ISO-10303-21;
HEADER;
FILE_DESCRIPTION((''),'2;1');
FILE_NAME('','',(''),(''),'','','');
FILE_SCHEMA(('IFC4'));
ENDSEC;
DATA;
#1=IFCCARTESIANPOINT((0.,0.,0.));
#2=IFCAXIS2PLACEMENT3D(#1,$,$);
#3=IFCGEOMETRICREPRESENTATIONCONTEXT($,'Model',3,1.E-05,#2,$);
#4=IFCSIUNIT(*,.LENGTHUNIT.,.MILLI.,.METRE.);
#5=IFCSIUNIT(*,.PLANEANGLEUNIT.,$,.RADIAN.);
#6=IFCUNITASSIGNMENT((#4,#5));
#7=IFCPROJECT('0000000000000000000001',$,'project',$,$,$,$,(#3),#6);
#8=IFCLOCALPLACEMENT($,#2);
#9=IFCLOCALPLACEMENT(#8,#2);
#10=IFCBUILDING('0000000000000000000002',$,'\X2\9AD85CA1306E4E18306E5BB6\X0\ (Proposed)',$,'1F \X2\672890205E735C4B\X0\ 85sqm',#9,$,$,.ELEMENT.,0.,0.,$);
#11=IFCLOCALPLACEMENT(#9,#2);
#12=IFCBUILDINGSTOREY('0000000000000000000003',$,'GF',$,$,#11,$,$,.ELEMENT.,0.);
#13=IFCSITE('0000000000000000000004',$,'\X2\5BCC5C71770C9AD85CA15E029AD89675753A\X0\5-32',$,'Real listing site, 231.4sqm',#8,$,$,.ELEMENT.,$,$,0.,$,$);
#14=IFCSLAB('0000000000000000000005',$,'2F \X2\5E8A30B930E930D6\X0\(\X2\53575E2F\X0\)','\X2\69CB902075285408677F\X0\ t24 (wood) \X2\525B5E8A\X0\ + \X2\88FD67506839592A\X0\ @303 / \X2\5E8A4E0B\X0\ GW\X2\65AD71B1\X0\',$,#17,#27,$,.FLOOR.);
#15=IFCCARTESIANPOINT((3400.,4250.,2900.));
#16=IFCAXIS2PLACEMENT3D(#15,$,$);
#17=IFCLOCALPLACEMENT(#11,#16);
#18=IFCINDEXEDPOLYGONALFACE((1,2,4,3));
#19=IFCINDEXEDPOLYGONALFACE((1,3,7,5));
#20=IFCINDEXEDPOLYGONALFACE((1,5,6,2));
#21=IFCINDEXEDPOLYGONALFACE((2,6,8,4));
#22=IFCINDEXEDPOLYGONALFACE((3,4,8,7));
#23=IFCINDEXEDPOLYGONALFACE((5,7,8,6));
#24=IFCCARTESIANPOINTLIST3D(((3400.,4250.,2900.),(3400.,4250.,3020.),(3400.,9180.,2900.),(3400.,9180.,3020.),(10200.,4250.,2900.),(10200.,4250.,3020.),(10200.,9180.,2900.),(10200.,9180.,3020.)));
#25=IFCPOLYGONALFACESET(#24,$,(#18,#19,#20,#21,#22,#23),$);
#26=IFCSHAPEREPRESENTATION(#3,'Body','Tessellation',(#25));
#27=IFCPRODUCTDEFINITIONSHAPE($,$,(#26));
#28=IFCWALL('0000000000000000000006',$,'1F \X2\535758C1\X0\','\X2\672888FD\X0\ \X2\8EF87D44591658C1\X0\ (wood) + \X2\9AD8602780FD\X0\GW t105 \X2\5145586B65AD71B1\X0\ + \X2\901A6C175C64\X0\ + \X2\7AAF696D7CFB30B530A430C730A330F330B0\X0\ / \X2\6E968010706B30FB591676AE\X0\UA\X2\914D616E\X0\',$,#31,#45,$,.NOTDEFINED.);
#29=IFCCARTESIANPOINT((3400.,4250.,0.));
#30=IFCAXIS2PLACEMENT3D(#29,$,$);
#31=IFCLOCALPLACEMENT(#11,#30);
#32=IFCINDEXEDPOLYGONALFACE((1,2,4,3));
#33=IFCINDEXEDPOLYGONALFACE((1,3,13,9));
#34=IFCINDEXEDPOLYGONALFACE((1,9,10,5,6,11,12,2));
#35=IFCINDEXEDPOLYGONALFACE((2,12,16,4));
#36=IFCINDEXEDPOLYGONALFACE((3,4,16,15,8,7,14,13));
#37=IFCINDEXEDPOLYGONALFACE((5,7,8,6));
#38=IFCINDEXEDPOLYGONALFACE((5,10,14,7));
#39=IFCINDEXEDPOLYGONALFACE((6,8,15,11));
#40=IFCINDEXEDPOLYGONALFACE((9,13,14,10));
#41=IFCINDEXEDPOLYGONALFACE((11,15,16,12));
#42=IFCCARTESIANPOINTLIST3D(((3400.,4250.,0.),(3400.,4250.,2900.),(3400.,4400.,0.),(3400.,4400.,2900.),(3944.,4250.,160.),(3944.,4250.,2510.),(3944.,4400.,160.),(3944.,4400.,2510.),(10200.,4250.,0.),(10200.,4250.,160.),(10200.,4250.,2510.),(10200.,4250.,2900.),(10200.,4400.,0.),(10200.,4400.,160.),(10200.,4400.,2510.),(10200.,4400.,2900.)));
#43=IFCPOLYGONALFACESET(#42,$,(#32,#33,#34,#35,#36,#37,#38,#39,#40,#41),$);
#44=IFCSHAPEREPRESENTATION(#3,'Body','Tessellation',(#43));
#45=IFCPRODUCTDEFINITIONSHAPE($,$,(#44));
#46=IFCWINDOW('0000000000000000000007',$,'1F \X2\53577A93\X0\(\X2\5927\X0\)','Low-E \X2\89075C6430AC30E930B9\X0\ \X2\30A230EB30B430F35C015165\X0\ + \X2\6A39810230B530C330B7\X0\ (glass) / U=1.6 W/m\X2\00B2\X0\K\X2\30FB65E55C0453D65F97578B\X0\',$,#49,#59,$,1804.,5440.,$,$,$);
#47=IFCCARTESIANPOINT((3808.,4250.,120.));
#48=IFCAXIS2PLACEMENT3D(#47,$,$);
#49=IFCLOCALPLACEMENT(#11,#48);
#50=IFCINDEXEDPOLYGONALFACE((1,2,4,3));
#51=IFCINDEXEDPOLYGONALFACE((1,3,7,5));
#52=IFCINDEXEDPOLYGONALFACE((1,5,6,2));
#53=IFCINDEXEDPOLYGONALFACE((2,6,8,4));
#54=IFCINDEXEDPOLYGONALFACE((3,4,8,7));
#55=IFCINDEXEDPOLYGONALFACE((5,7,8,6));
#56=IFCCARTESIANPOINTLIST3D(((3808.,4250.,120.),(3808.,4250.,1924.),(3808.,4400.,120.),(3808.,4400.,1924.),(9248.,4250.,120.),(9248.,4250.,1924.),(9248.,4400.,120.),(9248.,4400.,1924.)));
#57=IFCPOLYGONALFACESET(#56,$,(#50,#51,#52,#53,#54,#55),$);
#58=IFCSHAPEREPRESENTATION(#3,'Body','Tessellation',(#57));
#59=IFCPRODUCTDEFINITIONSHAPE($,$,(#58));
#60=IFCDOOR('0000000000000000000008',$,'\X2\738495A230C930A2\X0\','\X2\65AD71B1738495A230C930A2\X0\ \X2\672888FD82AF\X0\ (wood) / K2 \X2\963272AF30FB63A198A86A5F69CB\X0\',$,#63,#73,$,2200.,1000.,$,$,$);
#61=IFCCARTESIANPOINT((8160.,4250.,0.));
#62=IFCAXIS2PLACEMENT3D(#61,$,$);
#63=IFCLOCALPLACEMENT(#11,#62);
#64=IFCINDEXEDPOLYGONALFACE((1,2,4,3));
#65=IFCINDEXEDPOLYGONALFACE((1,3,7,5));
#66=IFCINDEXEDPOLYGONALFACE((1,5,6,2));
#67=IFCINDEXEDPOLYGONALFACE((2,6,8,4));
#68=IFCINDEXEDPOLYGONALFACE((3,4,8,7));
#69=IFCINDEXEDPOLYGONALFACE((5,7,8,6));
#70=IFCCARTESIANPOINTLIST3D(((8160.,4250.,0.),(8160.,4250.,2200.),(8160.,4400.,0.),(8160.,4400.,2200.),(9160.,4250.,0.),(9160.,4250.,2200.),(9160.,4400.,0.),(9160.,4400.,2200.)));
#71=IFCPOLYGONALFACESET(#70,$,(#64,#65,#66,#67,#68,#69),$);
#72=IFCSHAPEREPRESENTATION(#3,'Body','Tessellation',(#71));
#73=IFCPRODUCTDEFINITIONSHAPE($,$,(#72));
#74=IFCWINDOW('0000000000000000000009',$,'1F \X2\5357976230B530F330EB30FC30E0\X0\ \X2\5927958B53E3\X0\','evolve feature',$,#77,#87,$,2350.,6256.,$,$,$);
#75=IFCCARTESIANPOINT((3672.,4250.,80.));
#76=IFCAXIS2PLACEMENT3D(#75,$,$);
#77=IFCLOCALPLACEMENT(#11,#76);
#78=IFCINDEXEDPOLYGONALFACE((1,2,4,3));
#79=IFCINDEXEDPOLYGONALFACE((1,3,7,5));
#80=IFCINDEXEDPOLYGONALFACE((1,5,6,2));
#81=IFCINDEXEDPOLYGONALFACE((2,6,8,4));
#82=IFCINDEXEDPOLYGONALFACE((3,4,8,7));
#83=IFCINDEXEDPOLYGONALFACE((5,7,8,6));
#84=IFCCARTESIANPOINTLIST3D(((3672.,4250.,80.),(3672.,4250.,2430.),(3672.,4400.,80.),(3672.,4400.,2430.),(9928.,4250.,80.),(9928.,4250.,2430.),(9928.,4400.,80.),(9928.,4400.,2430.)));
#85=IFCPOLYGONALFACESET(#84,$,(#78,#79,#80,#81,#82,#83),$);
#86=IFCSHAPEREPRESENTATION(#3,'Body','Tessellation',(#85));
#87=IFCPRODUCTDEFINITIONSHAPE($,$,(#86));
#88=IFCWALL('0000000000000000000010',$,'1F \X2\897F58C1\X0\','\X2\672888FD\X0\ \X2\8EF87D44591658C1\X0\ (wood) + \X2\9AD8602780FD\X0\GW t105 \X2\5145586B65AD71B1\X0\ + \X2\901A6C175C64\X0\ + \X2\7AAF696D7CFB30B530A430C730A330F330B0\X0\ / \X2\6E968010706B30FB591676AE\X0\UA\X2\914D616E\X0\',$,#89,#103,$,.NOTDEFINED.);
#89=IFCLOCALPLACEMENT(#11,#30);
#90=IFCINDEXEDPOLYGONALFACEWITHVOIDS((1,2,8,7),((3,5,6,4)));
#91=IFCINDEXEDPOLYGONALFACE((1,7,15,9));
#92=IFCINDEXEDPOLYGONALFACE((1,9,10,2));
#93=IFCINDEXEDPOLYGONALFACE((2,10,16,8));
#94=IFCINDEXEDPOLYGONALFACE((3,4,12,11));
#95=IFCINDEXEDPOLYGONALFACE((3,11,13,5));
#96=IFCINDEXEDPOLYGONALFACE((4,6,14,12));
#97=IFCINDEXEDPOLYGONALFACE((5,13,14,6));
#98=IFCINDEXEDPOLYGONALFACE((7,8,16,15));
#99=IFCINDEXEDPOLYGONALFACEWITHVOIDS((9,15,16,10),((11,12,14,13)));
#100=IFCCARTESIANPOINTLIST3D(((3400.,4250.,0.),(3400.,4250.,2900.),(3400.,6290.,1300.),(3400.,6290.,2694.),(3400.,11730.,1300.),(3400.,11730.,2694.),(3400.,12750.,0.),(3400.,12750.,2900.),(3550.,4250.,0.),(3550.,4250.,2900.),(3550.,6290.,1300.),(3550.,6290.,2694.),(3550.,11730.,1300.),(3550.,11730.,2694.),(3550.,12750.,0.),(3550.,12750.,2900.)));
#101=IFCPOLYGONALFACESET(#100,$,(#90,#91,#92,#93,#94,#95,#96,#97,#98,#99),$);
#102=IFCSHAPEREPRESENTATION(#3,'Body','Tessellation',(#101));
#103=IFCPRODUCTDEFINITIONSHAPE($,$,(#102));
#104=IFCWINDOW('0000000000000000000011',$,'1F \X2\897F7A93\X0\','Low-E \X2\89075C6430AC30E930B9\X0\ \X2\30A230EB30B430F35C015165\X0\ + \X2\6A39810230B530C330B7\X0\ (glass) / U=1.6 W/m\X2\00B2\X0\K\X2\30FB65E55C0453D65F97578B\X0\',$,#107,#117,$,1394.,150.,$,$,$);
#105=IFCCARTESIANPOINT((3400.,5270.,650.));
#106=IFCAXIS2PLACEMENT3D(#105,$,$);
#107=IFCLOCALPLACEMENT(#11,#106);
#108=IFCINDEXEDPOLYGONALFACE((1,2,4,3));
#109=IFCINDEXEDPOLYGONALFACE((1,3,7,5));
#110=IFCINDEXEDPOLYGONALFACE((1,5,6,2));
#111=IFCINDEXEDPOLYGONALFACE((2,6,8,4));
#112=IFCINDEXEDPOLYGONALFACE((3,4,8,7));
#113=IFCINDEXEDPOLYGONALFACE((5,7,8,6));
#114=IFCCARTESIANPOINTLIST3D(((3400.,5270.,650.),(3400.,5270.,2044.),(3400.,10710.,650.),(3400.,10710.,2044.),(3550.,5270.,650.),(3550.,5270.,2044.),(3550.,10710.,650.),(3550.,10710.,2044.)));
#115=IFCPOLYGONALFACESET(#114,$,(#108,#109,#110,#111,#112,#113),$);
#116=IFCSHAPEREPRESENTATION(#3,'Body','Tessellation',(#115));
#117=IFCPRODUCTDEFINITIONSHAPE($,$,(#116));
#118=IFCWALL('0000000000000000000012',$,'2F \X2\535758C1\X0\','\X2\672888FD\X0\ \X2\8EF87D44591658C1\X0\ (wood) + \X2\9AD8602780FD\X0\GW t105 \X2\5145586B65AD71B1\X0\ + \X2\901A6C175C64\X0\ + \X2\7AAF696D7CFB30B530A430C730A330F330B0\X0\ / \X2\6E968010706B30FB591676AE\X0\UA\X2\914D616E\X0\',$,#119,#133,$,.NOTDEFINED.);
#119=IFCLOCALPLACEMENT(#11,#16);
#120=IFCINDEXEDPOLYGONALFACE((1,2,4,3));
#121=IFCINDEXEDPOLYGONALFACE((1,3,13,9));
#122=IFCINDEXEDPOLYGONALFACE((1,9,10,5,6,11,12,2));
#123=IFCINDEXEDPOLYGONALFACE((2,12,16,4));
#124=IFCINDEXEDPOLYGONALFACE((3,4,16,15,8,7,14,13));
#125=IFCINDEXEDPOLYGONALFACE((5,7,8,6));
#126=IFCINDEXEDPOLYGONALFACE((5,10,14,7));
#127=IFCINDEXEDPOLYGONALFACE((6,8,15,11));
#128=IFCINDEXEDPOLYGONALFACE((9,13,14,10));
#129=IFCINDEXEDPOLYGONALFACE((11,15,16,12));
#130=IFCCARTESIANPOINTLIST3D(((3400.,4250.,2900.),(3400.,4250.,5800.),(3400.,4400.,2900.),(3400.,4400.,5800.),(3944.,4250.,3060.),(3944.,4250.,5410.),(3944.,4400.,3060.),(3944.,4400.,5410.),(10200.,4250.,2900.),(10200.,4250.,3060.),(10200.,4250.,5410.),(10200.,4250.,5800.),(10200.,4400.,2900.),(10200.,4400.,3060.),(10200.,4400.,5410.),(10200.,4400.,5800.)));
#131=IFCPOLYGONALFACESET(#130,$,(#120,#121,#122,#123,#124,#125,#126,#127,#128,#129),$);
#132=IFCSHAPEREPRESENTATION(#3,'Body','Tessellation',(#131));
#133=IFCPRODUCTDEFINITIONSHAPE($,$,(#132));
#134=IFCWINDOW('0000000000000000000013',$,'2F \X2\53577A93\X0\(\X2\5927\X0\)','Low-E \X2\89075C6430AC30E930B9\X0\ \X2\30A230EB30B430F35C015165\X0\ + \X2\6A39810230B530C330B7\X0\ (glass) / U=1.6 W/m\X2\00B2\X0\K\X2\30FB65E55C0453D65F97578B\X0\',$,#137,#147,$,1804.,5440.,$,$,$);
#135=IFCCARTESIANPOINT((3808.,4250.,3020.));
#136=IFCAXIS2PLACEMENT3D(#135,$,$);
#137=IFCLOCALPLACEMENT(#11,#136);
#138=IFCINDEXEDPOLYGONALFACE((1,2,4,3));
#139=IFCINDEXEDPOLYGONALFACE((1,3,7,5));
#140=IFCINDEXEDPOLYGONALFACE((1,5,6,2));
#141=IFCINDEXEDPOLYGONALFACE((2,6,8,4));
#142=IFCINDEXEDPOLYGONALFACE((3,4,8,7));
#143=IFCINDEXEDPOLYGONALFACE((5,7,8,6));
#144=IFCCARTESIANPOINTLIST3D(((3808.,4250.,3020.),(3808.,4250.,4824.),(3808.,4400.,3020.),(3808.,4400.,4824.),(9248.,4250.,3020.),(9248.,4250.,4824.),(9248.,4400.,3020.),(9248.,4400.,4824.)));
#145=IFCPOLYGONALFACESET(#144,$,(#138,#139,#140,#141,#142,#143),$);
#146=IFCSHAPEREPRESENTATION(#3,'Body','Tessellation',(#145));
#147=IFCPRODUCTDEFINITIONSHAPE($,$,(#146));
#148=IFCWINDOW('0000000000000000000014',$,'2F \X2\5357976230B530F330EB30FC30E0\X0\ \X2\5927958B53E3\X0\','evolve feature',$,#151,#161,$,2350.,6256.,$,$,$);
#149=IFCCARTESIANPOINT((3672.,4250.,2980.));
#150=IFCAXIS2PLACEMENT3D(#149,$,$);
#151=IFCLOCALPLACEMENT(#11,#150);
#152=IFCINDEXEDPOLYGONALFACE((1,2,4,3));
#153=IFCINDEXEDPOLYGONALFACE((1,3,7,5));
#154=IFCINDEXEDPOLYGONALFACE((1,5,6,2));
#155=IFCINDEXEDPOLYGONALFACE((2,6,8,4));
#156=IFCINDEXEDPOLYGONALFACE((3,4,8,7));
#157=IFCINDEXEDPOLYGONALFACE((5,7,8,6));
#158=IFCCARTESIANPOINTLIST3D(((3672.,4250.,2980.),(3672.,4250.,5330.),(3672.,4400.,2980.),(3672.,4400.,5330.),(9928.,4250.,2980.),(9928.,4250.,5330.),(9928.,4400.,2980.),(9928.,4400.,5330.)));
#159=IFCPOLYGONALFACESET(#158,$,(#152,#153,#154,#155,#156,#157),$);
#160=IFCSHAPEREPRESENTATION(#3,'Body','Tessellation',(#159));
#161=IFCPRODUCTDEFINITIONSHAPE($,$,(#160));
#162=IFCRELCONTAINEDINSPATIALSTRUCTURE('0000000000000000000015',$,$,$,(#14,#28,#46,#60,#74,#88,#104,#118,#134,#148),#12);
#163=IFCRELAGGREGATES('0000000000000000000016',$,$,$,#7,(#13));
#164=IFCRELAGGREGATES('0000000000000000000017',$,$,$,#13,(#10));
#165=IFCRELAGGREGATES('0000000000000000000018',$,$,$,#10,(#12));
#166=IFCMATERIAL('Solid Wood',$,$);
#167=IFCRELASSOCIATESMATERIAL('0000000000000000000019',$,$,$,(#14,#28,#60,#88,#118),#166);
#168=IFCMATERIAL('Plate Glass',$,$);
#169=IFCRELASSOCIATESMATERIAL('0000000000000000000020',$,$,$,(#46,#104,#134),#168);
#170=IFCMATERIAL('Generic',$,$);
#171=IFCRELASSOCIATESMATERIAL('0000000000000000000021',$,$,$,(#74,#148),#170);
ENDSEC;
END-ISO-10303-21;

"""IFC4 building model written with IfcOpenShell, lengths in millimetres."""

from ifc_helpers import new_model, si_unit, frame, frame_2d, origin, place, context, project, spatial, rectangle, extrude, material, element, fill, save


model = new_model("IFC4")

# Units and contexts
model_context = context("Model", 3, precision=1e-05, world=origin())
ifc_project = project(units=[si_unit("LENGTHUNIT", "METRE", prefix="MILLI"), si_unit("PLANEANGLEUNIT", "RADIAN")], contexts=[model_context])

# Site, building, storey
site_placement = place(None, origin())
site = spatial("IfcSite", under=ifc_project, at=site_placement, Name="富山県高岡市高陵町5-32", ObjectType="Real listing site, 231.4sqm", CompositionType="ELEMENT", RefElevation=0.0)
building_placement = place(site_placement, origin())
building = spatial("IfcBuilding", under=site, at=building_placement, Name="高岡の丘の家 (Proposed)", ObjectType="1F 木造平屋 85sqm", CompositionType="ELEMENT", ElevationOfRefHeight=0.0, ElevationOfTerrain=0.0)
storey_placement = place(building_placement, origin())
storey = spatial("IfcBuildingStorey", under=building, at=storey_placement, Name="GF", CompositionType="ELEMENT", Elevation=0.0)

# Slab
ifc_material_1 = material(Name="Solid Wood")
slab_1_placement = place(storey_placement, frame((3400.0, 4250.0, 2900.0)))
element("IfcSlab", 1, at=slab_1_placement, inside=storey, material=ifc_material_1, Name="2F 床スラブ(南帯)", Description="構造用合板 t24 (wood) 剛床 + 製材根太 @303 / 床下 GW断熱", PredefinedType="FLOOR", context=model_context, shape_type="SweptSolid", body=[
    extrude(rectangle(XDim=6800.0, YDim=4930.0, at=frame_2d((3400.0, 2465.0))), frame((3400.0, 4250.0, 2900.0)), (0.0, 0.0, 1.0), 120.0),
])
ifc_material_2 = material(Name="Generic")

# Wall, openings, windows, door
wall_1_placement = place(storey_placement, frame((3400.0, 4250.0, 0.0)))
wall_1 = element("IfcWall", 2, at=wall_1_placement, inside=storey, material=ifc_material_1, Name="1F 南壁", Description="木製 軸組外壁 (wood) + 高性能GW t105 充填断熱 + 通気層 + 窯業系サイディング / 準耐火・外皮UA配慮", PredefinedType="NOTDEFINED", context=model_context, shape_type="SweptSolid", body=[
    extrude(rectangle(XDim=6800.0, YDim=150.0, at=frame_2d((3400.0, 75.0))), frame((3400.0, 4250.0, 0.0)), (0.0, 0.0, 1.0), 2900.0),
])
opening_1_placement = place(storey_placement, frame((3808.0, 4250.0, 120.0)))
opening_1 = element("IfcOpeningElement", 3, at=opening_1_placement, cuts=wall_1, PredefinedType="NOTDEFINED", context=model_context, shape_type="SweptSolid", body=[
    extrude(rectangle(XDim=5440.0, YDim=150.0, at=frame_2d((2720.0, 75.0))), frame((3808.0, 4250.0, 120.0)), (0.0, 0.0, 1.0), 1804.0),
])
opening_2_placement = place(storey_placement, frame((8160.0, 4250.0, 0.0)))
opening_2 = element("IfcOpeningElement", 4, at=opening_2_placement, cuts=wall_1, PredefinedType="NOTDEFINED", context=model_context, shape_type="SweptSolid", body=[
    extrude(rectangle(XDim=1000.0, YDim=150.0, at=frame_2d((500.0, 75.0))), frame((8160.0, 4250.0, 0.0)), (0.0, 0.0, 1.0), 2200.0),
])
opening_3_placement = place(storey_placement, frame((3672.0, 4250.0, 80.0)))
opening_3 = element("IfcOpeningElement", 5, at=opening_3_placement, cuts=wall_1, PredefinedType="NOTDEFINED", context=model_context, shape_type="SweptSolid", body=[
    extrude(rectangle(XDim=6256.0, YDim=150.0, at=frame_2d((3128.0, 75.0))), frame((3672.0, 4250.0, 80.0)), (0.0, 0.0, 1.0), 2350.0),
])
ifc_material_3 = material(Name="Plate Glass")
window_1_placement = place(storey_placement, frame((3808.0, 4250.0, 120.0)))
window_1 = element("IfcWindow", 6, at=window_1_placement, inside=storey, material=ifc_material_3, Name="1F 南窓(大)", Description="Low-E 複層ガラス アルゴン封入 + 樹脂サッシ (glass) / U=1.6 W/m²K・日射取得型", OverallHeight=1804.0, OverallWidth=5440.0, context=model_context, shape_type="SweptSolid", body=[
    extrude(rectangle(XDim=5440.0, YDim=150.0, at=frame_2d((2720.0, 75.0))), frame((3808.0, 4250.0, 120.0)), (0.0, 0.0, 1.0), 1804.0),
])
fill(opening_1, window_1)
door_placement = place(storey_placement, frame((8160.0, 4250.0, 0.0)))
door = element("IfcDoor", 7, at=door_placement, inside=storey, material=ifc_material_1, Name="玄関ドア", Description="断熱玄関ドア 木製芯 (wood) / K2 防犯・採風機構", OverallHeight=2200.0, OverallWidth=1000.0, context=model_context, shape_type="SweptSolid", body=[
    extrude(rectangle(XDim=1000.0, YDim=150.0, at=frame_2d((500.0, 75.0))), frame((8160.0, 4250.0, 0.0)), (0.0, 0.0, 1.0), 2200.0),
])
fill(opening_2, door)
window_2_placement = place(storey_placement, frame((3672.0, 4250.0, 80.0)))
window_2 = element("IfcWindow", 8, at=window_2_placement, inside=storey, material=ifc_material_2, Name="1F 南面サンルーム 大開口", Description="evolve feature", OverallHeight=2350.0, OverallWidth=6256.0, context=model_context, shape_type="SweptSolid", body=[
    extrude(rectangle(XDim=6256.0, YDim=150.0, at=frame_2d((3128.0, 75.0))), frame((3672.0, 4250.0, 80.0)), (0.0, 0.0, 1.0), 2350.0),
])
fill(opening_3, window_2)

# Wall, opening, window
wall_2_placement = place(storey_placement, frame((3400.0, 4250.0, 0.0)))
wall_2 = element("IfcWall", 9, at=wall_2_placement, inside=storey, material=ifc_material_1, Name="1F 西壁", Description="木製 軸組外壁 (wood) + 高性能GW t105 充填断熱 + 通気層 + 窯業系サイディング / 準耐火・外皮UA配慮", PredefinedType="NOTDEFINED", context=model_context, shape_type="SweptSolid", body=[
    extrude(rectangle(XDim=150.0, YDim=8500.0, at=frame_2d((75.0, 4250.0))), frame((3400.0, 4250.0, 0.0)), (0.0, 0.0, 1.0), 2900.0),
])
opening_4_placement = place(storey_placement, frame((3400.0, 5270.0, 650.0)))
opening_4 = element("IfcOpeningElement", 10, at=opening_4_placement, cuts=wall_2, PredefinedType="NOTDEFINED", context=model_context, shape_type="SweptSolid", body=[
    extrude(rectangle(XDim=150.0, YDim=5440.0, at=frame_2d((75.0, 2720.0))), frame((3400.0, 5270.0, 650.0)), (0.0, 0.0, 1.0), 1394.0),
])
window_3_placement = place(storey_placement, frame((3400.0, 5270.0, 650.0)))
window_3 = element("IfcWindow", 11, at=window_3_placement, inside=storey, material=ifc_material_3, Name="1F 西窓", Description="Low-E 複層ガラス アルゴン封入 + 樹脂サッシ (glass) / U=1.6 W/m²K・日射取得型", OverallHeight=1394.0, OverallWidth=150.0, context=model_context, shape_type="SweptSolid", body=[
    extrude(rectangle(XDim=150.0, YDim=5440.0, at=frame_2d((75.0, 2720.0))), frame((3400.0, 5270.0, 650.0)), (0.0, 0.0, 1.0), 1394.0),
])
fill(opening_4, window_3)

# Wall, openings, windows
wall_3_placement = place(storey_placement, frame((3400.0, 4250.0, 2900.0)))
wall_3 = element("IfcWall", 12, at=wall_3_placement, inside=storey, material=ifc_material_1, Name="2F 南壁", Description="木製 軸組外壁 (wood) + 高性能GW t105 充填断熱 + 通気層 + 窯業系サイディング / 準耐火・外皮UA配慮", PredefinedType="NOTDEFINED", context=model_context, shape_type="SweptSolid", body=[
    extrude(rectangle(XDim=6800.0, YDim=150.0, at=frame_2d((3400.0, 75.0))), frame((3400.0, 4250.0, 2900.0)), (0.0, 0.0, 1.0), 2900.0),
])
opening_5_placement = place(storey_placement, frame((3808.0, 4250.0, 3020.0)))
opening_5 = element("IfcOpeningElement", 13, at=opening_5_placement, cuts=wall_3, PredefinedType="NOTDEFINED", context=model_context, shape_type="SweptSolid", body=[
    extrude(rectangle(XDim=5440.0, YDim=150.0, at=frame_2d((2720.0, 75.0))), frame((3808.0, 4250.0, 3020.0)), (0.0, 0.0, 1.0), 1804.0),
])
opening_6_placement = place(storey_placement, frame((3672.0, 4250.0, 2980.0)))
opening_6 = element("IfcOpeningElement", 14, at=opening_6_placement, cuts=wall_3, PredefinedType="NOTDEFINED", context=model_context, shape_type="SweptSolid", body=[
    extrude(rectangle(XDim=6256.0, YDim=150.0, at=frame_2d((3128.0, 75.0))), frame((3672.0, 4250.0, 2980.0)), (0.0, 0.0, 1.0), 2350.0),
])
window_4_placement = place(storey_placement, frame((3808.0, 4250.0, 3020.0)))
window_4 = element("IfcWindow", 15, at=window_4_placement, inside=storey, material=ifc_material_3, Name="2F 南窓(大)", Description="Low-E 複層ガラス アルゴン封入 + 樹脂サッシ (glass) / U=1.6 W/m²K・日射取得型", OverallHeight=1804.0, OverallWidth=5440.0, context=model_context, shape_type="SweptSolid", body=[
    extrude(rectangle(XDim=5440.0, YDim=150.0, at=frame_2d((2720.0, 75.0))), frame((3808.0, 4250.0, 3020.0)), (0.0, 0.0, 1.0), 1804.0),
])
fill(opening_5, window_4)
window_5_placement = place(storey_placement, frame((3672.0, 4250.0, 2980.0)))
window_5 = element("IfcWindow", 16, at=window_5_placement, inside=storey, material=ifc_material_2, Name="2F 南面サンルーム 大開口", Description="evolve feature", OverallHeight=2350.0, OverallWidth=6256.0, context=model_context, shape_type="SweptSolid", body=[
    extrude(rectangle(XDim=6256.0, YDim=150.0, at=frame_2d((3128.0, 75.0))), frame((3672.0, 4250.0, 2980.0)), (0.0, 0.0, 1.0), 2350.0),
])
fill(opening_6, window_5)

save(model, "model.ifc")
